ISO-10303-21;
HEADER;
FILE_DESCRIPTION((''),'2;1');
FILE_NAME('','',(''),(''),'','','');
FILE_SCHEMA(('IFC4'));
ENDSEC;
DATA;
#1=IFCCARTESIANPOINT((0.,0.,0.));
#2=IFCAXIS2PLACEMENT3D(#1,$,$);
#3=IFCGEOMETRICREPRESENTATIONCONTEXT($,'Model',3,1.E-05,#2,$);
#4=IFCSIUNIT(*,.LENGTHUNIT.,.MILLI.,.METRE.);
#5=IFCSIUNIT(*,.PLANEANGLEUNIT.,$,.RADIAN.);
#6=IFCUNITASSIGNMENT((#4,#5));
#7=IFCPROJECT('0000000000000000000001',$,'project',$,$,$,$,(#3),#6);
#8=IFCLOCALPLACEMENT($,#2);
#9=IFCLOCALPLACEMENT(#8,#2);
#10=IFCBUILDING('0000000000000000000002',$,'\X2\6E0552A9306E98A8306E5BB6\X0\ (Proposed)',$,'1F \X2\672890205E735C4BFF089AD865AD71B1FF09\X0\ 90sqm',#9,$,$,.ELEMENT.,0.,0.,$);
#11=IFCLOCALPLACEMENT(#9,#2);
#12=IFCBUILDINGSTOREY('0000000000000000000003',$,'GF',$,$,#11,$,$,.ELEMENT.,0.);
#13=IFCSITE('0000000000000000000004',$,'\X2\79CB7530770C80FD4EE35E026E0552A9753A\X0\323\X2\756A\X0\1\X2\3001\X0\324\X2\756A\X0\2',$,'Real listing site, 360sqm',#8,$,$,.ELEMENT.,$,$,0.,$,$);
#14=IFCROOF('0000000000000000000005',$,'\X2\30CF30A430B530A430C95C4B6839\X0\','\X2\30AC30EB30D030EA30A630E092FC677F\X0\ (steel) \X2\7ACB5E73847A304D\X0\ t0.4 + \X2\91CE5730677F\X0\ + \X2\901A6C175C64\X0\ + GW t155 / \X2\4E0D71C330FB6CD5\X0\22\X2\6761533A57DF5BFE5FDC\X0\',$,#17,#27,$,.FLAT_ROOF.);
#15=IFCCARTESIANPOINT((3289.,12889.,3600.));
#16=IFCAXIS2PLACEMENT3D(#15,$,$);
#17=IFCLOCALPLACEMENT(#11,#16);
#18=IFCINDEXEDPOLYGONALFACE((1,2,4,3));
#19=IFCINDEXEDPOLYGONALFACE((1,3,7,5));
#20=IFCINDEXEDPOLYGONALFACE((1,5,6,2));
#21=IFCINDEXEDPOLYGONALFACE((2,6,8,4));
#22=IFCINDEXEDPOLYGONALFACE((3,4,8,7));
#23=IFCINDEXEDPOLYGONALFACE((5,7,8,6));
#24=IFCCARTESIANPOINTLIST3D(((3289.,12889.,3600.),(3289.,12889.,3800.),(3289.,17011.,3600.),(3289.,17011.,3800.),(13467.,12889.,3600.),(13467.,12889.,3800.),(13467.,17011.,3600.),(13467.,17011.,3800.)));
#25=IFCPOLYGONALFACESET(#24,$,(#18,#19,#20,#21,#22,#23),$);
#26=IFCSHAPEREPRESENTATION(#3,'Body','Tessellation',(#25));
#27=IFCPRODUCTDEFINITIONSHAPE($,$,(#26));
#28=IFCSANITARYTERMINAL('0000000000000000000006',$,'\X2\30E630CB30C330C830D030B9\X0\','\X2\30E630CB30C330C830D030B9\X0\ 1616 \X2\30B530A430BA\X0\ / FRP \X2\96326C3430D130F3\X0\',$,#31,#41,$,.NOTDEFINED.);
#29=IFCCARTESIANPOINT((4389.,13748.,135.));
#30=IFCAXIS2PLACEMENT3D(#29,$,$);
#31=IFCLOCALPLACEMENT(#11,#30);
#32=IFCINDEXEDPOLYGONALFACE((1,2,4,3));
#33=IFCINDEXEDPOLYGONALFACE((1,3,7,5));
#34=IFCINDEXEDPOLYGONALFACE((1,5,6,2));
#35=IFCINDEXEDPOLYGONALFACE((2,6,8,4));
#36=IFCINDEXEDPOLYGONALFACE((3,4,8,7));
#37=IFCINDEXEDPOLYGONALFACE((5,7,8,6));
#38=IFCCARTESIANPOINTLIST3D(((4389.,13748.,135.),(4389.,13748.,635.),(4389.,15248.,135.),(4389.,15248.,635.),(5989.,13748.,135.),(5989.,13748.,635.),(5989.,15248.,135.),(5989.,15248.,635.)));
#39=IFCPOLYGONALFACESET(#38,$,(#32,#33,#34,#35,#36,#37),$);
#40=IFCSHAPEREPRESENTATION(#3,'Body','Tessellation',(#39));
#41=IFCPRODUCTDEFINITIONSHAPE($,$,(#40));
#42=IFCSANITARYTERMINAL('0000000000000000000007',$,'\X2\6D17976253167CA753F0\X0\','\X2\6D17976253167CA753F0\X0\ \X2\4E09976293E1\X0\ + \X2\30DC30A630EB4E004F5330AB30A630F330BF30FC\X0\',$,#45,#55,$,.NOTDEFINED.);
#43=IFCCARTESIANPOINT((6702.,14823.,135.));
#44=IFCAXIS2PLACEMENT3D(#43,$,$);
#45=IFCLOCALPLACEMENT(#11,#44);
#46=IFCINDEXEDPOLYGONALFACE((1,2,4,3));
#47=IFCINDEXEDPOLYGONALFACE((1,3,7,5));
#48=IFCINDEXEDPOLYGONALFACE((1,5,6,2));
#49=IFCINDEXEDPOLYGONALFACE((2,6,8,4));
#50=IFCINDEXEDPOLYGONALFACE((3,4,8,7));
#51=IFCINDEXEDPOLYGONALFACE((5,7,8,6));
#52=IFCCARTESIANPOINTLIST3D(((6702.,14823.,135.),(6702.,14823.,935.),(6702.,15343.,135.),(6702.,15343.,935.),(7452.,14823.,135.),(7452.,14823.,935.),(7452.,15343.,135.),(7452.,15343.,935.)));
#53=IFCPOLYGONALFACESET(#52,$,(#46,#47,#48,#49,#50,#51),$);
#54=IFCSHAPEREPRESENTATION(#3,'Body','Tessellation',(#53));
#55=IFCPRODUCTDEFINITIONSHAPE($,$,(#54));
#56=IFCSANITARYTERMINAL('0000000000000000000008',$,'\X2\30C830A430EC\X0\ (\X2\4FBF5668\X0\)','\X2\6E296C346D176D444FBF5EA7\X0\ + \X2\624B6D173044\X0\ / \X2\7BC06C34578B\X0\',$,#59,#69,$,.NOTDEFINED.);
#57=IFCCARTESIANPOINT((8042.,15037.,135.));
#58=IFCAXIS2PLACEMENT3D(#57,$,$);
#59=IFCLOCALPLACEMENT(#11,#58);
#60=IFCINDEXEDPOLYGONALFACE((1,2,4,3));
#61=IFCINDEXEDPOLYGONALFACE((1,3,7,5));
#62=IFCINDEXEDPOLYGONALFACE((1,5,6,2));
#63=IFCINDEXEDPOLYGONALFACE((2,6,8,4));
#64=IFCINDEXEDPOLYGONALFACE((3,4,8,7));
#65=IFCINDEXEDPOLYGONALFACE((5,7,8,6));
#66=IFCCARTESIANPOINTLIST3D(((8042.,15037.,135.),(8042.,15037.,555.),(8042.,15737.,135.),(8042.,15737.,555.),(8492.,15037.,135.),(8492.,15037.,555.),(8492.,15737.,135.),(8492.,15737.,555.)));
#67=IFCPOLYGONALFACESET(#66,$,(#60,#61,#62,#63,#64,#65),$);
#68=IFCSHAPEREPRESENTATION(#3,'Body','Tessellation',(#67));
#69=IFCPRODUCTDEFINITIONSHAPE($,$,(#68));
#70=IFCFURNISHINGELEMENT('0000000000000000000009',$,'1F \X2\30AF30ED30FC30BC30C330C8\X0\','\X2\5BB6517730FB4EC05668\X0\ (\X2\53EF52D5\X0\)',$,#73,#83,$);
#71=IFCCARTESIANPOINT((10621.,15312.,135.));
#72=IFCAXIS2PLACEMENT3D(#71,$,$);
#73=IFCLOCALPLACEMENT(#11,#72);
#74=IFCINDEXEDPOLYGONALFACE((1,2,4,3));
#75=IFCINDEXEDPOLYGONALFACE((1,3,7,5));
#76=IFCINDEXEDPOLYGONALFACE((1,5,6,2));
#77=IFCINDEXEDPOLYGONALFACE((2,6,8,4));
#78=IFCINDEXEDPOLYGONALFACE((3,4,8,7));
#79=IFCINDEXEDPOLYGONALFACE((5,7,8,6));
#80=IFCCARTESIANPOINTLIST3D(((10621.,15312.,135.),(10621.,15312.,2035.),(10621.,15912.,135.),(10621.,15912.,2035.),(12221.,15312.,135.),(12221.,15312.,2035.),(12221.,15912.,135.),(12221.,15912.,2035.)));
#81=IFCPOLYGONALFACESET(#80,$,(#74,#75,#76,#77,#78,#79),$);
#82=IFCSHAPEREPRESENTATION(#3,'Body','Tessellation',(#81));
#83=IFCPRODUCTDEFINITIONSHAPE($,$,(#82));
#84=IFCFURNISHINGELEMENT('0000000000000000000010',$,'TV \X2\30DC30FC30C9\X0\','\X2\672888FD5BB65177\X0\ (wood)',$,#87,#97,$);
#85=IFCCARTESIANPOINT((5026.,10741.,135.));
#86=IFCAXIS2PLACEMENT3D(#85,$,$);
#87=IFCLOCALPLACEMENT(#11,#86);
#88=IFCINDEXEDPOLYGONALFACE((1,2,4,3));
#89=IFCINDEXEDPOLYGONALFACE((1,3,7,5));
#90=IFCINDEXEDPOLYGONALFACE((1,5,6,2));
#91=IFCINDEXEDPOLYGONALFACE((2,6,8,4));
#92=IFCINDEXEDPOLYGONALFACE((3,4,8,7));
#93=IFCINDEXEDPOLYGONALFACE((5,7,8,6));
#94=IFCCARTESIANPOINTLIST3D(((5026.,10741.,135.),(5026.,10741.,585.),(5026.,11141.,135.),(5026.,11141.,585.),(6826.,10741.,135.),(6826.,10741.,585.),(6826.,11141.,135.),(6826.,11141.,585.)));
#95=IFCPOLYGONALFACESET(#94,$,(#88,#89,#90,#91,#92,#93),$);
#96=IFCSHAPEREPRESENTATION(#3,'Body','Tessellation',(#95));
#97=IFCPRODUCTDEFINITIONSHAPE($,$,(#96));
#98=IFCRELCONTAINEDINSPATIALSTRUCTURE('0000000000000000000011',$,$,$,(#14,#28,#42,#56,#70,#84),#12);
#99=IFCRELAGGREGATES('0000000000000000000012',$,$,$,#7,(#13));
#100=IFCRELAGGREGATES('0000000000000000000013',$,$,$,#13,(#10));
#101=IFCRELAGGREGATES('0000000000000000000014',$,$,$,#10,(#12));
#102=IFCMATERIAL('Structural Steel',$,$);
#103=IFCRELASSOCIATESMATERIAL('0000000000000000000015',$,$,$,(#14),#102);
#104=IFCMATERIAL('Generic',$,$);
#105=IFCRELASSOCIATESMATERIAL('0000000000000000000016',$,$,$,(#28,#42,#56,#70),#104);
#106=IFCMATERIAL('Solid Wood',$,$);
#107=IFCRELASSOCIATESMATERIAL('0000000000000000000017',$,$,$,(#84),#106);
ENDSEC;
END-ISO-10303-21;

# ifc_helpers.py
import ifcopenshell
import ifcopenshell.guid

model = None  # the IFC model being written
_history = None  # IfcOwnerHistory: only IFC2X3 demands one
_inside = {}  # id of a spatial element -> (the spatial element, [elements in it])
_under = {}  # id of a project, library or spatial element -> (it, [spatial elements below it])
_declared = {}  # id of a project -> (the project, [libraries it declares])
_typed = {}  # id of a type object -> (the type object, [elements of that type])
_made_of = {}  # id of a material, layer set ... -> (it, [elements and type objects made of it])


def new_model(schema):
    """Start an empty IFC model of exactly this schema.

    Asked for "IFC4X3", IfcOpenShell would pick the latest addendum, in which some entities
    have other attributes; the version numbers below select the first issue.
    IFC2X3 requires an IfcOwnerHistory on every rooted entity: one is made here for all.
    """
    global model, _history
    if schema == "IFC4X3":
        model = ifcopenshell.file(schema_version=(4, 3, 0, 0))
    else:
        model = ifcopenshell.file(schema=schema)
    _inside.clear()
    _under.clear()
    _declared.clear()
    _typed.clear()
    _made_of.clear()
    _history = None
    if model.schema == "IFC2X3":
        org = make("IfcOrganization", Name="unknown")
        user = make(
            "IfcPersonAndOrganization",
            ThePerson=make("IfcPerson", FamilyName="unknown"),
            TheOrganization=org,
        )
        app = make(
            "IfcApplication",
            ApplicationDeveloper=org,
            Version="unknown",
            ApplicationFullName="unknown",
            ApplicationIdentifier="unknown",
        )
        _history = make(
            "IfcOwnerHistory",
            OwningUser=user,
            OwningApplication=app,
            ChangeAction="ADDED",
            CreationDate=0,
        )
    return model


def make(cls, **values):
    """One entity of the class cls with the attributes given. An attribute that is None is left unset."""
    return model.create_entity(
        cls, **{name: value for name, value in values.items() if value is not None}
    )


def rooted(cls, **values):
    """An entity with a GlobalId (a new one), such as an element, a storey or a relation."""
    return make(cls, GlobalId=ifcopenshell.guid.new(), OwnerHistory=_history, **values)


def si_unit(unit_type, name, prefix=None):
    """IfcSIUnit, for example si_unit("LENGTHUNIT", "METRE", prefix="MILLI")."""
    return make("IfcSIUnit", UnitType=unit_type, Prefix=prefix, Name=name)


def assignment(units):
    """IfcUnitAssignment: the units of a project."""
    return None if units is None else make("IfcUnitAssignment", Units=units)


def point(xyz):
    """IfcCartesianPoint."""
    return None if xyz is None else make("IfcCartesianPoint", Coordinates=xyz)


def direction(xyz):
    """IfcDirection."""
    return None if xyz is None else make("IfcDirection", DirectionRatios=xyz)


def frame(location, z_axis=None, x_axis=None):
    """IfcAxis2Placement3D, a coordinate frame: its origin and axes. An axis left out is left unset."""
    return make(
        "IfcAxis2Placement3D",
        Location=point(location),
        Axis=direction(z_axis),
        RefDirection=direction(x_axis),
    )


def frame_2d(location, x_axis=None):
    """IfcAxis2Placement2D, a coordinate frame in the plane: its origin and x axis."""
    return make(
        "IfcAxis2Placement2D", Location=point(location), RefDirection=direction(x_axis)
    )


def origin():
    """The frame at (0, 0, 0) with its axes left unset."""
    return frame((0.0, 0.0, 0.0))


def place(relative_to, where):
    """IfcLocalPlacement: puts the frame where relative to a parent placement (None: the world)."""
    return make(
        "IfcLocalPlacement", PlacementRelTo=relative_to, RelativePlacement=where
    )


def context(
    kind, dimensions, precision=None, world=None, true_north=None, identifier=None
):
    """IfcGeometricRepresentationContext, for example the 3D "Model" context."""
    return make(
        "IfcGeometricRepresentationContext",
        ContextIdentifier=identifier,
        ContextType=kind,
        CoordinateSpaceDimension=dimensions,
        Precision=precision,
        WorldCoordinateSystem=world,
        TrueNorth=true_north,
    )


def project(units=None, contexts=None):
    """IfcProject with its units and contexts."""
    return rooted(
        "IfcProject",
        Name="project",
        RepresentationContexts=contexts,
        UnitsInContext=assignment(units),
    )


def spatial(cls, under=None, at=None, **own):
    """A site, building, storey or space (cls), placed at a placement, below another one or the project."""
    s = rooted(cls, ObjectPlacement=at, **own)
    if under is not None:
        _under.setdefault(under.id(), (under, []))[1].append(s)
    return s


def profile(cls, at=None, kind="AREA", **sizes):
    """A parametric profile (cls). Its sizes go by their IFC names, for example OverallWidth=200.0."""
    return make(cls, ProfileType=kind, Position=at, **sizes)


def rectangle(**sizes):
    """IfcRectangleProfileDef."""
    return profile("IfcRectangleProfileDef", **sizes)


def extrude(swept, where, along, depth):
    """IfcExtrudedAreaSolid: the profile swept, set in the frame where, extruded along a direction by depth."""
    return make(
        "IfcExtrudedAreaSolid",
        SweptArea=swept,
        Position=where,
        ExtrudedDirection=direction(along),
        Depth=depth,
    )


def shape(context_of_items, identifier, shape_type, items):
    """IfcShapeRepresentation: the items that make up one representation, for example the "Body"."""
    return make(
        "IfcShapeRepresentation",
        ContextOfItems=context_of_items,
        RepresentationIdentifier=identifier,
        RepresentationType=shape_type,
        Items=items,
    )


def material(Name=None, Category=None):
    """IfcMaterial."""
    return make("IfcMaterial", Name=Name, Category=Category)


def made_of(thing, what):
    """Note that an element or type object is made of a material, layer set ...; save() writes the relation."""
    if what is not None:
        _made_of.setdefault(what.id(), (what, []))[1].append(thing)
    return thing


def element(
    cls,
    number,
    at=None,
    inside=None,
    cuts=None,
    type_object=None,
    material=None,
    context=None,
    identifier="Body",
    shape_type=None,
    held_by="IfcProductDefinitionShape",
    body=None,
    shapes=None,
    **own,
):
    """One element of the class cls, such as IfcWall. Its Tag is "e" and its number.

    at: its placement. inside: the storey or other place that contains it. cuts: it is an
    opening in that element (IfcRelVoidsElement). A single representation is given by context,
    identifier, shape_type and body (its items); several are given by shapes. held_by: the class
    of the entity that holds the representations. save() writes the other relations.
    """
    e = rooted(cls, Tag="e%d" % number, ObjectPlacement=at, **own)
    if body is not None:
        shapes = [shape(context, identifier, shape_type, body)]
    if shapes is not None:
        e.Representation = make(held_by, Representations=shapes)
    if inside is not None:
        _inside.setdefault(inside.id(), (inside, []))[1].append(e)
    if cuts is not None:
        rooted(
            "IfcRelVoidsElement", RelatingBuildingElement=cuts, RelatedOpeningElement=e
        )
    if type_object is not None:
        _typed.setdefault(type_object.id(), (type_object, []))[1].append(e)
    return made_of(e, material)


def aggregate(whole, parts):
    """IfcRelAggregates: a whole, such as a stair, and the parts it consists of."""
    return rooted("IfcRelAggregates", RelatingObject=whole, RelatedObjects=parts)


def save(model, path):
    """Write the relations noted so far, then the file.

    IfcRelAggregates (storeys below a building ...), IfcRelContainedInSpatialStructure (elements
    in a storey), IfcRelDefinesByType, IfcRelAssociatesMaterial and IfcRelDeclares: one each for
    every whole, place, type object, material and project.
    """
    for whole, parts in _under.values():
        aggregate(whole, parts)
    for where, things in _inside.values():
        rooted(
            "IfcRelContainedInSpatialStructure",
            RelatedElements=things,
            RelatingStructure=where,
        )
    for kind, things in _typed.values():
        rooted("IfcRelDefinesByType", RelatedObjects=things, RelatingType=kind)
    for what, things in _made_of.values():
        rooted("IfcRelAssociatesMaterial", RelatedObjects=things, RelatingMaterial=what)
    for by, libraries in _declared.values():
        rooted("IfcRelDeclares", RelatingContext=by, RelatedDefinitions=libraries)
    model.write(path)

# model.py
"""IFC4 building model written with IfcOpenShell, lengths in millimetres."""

from ifc_helpers import new_model, si_unit, frame, frame_2d, origin, place, context, project, spatial, rectangle, extrude, material, element, save


model = new_model("IFC4")

# Units and contexts
model_context = context("Model", 3, precision=1e-05, world=origin())
ifc_project = project(units=[si_unit("LENGTHUNIT", "METRE", prefix="MILLI"), si_unit("PLANEANGLEUNIT", "RADIAN")], contexts=[model_context])

# Site, building, storey
site_placement = place(None, origin())
site = spatial("IfcSite", under=ifc_project, at=site_placement, Name="秋田県能代市清助町323番1、324番2", ObjectType="Real listing site, 360sqm", CompositionType="ELEMENT", RefElevation=0.0)
building_placement = place(site_placement, origin())
building = spatial("IfcBuilding", under=site, at=building_placement, Name="清助の風の家 (Proposed)", ObjectType="1F 木造平屋（高断熱） 90sqm", CompositionType="ELEMENT", ElevationOfRefHeight=0.0, ElevationOfTerrain=0.0)
storey_placement = place(building_placement, origin())
storey = spatial("IfcBuildingStorey", under=building, at=storey_placement, Name="GF", CompositionType="ELEMENT", Elevation=0.0)

# Shared definitions
ifc_material_1 = material(Name="Solid Wood")

# Roof
ifc_material_2 = material(Name="Structural Steel")
roof_placement = place(storey_placement, frame((3289.0, 12889.0, 3600.0)))
element("IfcRoof", 1, at=roof_placement, inside=storey, material=ifc_material_2, Name="ハイサイド屋根", Description="ガルバリウム鋼板 (steel) 立平葺き t0.4 + 野地板 + 通気層 + GW t155 / 不燃・法22条区域対応", PredefinedType="FLAT_ROOF", context=model_context, shape_type="SweptSolid", body=[
    extrude(rectangle(XDim=10178.0, YDim=4122.0, at=frame_2d((5089.0, 2061.0))), frame((3289.0, 12889.0, 3600.0)), (0.0, 0.0, 1.0), 200.0),
])

# Sanitary terminals
ifc_material_3 = material(Name="Generic")
sanitary_terminal_1_placement = place(storey_placement, frame((4389.0, 13748.0, 135.0)))
element("IfcSanitaryTerminal", 2, at=sanitary_terminal_1_placement, inside=storey, material=ifc_material_3, Name="ユニットバス", Description="ユニットバス 1616 サイズ / FRP 防水パン", PredefinedType="NOTDEFINED", context=model_context, shape_type="SweptSolid", body=[
    extrude(rectangle(XDim=1600.0, YDim=1500.0, at=frame_2d((800.0, 750.0))), frame((4389.0, 13748.0, 135.0)), (0.0, 0.0, 1.0), 500.0),
])
sanitary_terminal_2_placement = place(storey_placement, frame((6702.0, 14823.0, 135.0)))
element("IfcSanitaryTerminal", 3, at=sanitary_terminal_2_placement, inside=storey, material=ifc_material_3, Name="洗面化粧台", Description="洗面化粧台 三面鏡 + ボウル一体カウンター", PredefinedType="NOTDEFINED", context=model_context, shape_type="SweptSolid", body=[
    extrude(rectangle(XDim=750.0, YDim=520.0, at=frame_2d((375.0, 260.0))), frame((6702.0, 14823.0, 135.0)), (0.0, 0.0, 1.0), 800.0),
])
sanitary_terminal_3_placement = place(storey_placement, frame((8042.0, 15037.0, 135.0)))
element("IfcSanitaryTerminal", 4, at=sanitary_terminal_3_placement, inside=storey, material=ifc_material_3, Name="トイレ (便器)", Description="温水洗浄便座 + 手洗い / 節水型", PredefinedType="NOTDEFINED", context=model_context, shape_type="SweptSolid", body=[
    extrude(rectangle(XDim=450.0, YDim=700.0, at=frame_2d((225.0, 350.0))), frame((8042.0, 15037.0, 135.0)), (0.0, 0.0, 1.0), 420.0),
])

# Furnishing elements
furnishing_1_placement = place(storey_placement, frame((10621.0, 15312.0, 135.0)))
element("IfcFurnishingElement", 5, at=furnishing_1_placement, inside=storey, material=ifc_material_3, Name="1F クローゼット", Description="家具・什器 (可動)", context=model_context, shape_type="SweptSolid", body=[
    extrude(rectangle(XDim=1600.0, YDim=600.0, at=frame_2d((800.0, 300.0))), frame((10621.0, 15312.0, 135.0)), (0.0, 0.0, 1.0), 1900.0),
])
furnishing_2_placement = place(storey_placement, frame((5026.0, 10741.0, 135.0)))
element("IfcFurnishingElement", 6, at=furnishing_2_placement, inside=storey, material=ifc_material_1, Name="TV ボード", Description="木製家具 (wood)", context=model_context, shape_type="SweptSolid", body=[
    extrude(rectangle(XDim=1800.0, YDim=400.0, at=frame_2d((900.0, 200.0))), frame((5026.0, 10741.0, 135.0)), (0.0, 0.0, 1.0), 450.0),
])

save(model, "model.ifc")
